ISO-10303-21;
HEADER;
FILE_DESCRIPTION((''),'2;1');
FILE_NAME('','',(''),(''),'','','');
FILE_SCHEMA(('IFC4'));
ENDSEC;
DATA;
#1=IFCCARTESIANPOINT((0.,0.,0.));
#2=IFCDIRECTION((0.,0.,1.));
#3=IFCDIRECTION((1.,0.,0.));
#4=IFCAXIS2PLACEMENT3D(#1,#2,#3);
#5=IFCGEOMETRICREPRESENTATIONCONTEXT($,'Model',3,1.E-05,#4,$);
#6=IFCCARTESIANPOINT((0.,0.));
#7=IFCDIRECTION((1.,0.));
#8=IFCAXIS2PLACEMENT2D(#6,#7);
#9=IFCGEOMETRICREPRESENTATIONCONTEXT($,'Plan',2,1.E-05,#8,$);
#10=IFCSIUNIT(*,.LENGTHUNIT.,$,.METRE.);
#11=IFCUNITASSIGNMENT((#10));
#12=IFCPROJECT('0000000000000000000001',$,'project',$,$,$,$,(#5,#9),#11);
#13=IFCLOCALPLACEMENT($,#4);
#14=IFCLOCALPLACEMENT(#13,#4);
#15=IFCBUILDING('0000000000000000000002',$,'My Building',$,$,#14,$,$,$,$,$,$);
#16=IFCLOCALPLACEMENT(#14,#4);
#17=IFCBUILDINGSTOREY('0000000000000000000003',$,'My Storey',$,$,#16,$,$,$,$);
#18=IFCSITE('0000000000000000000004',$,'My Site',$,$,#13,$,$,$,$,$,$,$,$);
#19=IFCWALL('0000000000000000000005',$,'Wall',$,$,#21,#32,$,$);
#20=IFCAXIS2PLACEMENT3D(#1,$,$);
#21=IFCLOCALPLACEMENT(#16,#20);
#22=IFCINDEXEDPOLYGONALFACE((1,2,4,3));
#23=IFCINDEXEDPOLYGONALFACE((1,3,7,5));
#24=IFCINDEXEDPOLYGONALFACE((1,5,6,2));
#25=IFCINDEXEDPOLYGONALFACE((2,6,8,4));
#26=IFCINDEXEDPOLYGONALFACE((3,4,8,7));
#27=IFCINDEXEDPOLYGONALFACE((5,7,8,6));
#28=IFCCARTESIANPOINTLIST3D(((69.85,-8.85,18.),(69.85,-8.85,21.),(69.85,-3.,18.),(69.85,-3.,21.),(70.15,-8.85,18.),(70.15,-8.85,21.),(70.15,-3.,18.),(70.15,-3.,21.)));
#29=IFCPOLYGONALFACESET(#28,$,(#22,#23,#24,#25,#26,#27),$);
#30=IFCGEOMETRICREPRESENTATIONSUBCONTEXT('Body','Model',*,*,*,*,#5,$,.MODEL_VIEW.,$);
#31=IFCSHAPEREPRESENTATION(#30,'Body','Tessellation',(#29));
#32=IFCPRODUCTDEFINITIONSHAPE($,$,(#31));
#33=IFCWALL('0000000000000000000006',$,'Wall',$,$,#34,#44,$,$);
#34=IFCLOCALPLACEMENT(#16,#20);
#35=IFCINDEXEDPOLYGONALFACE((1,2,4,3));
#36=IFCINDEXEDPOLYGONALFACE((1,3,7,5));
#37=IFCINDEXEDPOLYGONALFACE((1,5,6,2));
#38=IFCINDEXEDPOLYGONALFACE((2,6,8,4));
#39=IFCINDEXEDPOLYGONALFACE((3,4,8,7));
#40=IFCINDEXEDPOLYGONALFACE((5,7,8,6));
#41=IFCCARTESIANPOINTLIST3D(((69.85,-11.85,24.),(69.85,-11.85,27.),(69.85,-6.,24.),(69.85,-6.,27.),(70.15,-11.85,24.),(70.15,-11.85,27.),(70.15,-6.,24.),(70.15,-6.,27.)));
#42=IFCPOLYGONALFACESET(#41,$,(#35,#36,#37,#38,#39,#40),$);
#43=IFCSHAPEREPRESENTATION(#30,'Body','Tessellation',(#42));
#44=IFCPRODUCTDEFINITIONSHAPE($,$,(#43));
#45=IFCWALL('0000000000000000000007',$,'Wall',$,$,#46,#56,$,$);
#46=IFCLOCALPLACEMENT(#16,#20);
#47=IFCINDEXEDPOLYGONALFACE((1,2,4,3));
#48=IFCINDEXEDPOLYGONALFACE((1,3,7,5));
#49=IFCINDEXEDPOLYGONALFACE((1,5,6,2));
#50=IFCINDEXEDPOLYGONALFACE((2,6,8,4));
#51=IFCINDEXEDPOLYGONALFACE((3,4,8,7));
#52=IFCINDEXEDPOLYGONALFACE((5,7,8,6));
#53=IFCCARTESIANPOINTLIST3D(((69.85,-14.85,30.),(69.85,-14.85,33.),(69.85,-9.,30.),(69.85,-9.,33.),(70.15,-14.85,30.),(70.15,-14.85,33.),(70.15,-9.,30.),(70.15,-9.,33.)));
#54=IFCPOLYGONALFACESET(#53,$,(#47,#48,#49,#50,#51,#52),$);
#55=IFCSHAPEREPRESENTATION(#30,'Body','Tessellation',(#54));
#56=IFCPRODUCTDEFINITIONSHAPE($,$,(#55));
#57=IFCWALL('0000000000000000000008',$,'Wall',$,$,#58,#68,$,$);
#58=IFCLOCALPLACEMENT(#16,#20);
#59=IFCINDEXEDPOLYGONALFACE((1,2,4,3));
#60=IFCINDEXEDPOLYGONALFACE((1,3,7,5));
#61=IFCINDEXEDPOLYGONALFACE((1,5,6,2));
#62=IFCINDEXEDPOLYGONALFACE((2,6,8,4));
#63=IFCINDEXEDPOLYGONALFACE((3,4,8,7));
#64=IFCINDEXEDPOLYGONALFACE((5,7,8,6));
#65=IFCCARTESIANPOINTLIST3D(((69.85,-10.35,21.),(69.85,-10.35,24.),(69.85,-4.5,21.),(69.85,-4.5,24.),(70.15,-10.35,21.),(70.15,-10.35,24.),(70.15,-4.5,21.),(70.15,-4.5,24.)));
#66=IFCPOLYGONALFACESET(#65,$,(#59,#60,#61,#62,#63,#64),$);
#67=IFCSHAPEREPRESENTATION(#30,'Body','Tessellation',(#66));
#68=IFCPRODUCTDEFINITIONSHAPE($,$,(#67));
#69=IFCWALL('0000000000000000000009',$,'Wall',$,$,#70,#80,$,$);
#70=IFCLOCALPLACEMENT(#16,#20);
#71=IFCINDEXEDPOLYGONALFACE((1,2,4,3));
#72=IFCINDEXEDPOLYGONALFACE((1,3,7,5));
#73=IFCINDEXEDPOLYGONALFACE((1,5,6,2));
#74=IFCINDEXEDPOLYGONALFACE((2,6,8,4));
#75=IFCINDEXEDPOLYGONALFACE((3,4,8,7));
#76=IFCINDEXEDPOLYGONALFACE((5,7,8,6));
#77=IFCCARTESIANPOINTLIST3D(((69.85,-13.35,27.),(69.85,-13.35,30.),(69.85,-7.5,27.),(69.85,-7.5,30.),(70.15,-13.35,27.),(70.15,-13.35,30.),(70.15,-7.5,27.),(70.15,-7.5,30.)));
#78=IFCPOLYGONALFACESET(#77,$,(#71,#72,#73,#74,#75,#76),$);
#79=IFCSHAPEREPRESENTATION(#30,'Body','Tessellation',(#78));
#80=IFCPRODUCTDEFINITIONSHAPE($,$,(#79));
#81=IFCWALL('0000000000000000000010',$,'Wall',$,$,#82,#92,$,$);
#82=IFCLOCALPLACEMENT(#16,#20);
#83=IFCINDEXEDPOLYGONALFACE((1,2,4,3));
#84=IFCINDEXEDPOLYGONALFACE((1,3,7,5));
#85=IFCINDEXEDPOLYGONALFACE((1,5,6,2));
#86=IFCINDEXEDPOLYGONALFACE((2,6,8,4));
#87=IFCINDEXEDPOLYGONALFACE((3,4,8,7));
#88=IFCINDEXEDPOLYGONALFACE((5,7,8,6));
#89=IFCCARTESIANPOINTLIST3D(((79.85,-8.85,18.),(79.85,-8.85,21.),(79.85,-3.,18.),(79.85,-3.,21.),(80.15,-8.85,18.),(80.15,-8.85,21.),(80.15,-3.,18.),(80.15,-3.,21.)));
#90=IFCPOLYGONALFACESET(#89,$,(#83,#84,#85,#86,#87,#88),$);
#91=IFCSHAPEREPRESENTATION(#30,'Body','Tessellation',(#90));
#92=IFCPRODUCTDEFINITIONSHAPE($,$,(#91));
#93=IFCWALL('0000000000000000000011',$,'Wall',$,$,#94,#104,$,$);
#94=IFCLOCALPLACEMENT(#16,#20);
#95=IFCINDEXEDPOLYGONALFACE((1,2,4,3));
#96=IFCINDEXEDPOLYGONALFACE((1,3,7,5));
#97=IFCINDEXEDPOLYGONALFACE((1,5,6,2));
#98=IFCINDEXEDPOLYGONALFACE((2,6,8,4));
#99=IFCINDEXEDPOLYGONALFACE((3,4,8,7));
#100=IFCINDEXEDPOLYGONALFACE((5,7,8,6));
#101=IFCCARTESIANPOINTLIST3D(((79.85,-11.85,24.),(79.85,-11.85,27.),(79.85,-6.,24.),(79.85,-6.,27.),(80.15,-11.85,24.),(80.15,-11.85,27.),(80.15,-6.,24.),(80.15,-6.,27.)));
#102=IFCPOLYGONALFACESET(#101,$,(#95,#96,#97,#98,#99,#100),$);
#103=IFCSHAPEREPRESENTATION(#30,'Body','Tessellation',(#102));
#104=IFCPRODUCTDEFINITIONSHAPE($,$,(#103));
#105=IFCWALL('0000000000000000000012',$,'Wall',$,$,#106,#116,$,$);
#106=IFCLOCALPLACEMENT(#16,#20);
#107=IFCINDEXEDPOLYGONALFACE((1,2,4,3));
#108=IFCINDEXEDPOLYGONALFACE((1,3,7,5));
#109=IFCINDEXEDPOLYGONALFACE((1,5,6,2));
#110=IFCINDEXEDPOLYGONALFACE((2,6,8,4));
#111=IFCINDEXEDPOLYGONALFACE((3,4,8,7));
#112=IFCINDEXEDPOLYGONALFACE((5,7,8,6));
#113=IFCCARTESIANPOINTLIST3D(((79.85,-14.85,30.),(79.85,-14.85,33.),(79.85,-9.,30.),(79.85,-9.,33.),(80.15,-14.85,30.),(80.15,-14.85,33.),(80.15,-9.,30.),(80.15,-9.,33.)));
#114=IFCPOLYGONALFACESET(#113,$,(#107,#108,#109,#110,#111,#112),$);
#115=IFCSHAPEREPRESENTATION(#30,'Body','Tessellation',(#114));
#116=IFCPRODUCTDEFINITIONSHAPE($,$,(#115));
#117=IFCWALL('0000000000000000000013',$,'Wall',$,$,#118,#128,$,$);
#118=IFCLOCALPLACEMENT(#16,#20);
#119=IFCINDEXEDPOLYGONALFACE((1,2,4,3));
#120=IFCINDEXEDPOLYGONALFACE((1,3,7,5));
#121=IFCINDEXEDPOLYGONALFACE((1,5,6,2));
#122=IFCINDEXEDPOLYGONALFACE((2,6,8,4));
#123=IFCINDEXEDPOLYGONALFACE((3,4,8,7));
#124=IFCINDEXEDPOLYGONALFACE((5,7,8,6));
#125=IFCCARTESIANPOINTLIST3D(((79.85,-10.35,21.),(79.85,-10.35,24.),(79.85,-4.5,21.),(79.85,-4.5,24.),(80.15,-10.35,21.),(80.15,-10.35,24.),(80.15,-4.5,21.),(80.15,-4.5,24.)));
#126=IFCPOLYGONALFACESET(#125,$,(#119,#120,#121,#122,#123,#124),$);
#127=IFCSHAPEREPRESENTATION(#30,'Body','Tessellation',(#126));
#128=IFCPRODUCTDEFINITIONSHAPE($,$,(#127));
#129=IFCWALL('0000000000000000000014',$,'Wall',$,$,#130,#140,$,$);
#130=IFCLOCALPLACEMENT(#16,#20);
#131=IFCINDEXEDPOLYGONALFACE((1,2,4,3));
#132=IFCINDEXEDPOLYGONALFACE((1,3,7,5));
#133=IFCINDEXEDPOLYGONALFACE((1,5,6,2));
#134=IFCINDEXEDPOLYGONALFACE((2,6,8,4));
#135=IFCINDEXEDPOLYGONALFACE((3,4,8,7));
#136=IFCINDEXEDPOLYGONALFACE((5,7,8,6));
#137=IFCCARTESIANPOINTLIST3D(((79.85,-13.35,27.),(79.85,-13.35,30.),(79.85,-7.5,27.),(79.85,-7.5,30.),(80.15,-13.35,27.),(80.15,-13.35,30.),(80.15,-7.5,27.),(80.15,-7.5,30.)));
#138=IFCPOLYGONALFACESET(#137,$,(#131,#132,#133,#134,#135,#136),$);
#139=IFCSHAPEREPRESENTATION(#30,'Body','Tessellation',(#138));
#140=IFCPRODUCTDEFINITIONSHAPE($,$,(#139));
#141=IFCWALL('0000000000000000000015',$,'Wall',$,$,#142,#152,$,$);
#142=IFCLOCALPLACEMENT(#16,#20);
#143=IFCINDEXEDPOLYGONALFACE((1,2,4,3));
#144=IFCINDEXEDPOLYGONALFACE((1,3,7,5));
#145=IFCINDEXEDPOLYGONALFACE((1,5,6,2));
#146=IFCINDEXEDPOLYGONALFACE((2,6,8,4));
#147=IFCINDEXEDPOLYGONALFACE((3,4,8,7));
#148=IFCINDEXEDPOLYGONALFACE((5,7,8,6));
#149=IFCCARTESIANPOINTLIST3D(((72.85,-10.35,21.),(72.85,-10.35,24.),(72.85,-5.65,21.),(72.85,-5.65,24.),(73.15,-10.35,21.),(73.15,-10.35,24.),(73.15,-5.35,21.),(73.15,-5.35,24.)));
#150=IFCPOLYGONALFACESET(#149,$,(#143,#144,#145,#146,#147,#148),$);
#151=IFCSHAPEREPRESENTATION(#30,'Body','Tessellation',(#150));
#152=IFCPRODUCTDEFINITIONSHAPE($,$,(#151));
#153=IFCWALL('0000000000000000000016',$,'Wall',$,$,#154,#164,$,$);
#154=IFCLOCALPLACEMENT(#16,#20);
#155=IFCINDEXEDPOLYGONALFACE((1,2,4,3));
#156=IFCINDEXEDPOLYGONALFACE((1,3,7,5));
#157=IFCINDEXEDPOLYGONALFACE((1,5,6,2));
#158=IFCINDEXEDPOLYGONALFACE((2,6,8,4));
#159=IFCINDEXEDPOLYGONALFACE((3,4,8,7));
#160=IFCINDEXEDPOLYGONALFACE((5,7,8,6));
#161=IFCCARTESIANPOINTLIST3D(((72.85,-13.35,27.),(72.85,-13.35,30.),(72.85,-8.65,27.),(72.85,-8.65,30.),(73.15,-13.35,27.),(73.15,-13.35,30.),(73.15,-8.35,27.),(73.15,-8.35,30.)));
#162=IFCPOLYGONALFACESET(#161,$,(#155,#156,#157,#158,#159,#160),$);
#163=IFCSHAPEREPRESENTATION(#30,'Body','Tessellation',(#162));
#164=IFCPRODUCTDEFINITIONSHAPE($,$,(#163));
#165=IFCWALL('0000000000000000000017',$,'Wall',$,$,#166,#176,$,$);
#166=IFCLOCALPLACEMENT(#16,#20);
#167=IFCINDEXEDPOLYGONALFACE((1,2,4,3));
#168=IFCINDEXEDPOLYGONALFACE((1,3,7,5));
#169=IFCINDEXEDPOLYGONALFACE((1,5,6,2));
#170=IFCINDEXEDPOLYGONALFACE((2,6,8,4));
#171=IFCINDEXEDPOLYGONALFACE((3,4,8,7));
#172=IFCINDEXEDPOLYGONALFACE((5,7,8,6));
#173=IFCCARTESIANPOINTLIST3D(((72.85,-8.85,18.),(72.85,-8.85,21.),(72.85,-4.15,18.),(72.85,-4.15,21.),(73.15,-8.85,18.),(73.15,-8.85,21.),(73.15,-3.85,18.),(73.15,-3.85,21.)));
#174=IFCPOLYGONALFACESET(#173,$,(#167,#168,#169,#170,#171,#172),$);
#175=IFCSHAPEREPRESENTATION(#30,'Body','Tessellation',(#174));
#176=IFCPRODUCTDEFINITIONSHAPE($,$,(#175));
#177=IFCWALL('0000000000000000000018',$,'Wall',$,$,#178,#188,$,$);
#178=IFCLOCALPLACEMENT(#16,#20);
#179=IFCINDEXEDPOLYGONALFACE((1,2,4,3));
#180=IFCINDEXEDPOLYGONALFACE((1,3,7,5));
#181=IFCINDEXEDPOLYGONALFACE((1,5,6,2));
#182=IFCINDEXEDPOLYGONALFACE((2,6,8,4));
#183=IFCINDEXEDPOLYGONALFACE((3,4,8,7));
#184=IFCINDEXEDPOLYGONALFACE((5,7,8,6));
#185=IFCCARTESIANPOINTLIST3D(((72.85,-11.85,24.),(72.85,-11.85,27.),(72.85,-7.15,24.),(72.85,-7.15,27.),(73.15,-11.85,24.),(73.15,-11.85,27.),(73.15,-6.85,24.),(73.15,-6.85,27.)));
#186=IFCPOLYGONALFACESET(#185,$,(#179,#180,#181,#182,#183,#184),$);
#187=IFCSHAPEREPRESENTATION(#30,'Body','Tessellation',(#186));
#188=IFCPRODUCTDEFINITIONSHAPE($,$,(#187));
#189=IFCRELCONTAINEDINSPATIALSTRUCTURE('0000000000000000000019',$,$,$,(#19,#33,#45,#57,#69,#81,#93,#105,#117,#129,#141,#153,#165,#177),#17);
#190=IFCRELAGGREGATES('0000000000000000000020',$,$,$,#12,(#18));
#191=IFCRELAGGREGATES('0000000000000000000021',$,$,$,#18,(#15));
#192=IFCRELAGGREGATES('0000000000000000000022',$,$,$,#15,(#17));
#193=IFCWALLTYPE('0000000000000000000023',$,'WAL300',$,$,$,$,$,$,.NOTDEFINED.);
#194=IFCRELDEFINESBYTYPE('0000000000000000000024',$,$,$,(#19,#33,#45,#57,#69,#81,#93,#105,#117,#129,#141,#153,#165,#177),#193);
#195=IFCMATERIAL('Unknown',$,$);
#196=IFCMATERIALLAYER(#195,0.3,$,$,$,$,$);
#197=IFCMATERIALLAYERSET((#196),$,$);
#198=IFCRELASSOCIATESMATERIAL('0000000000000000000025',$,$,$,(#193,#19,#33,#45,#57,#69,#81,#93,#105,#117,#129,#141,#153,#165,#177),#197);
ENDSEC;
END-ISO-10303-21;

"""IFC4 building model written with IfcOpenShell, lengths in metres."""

from ifc_helpers import new_model, si_unit, frame, origin_with_axes, origin_2d_with_axis, place, context, subcontext, project, spatial, line, indexed_curve, outline, extrude, material, layer, layer_set, layer_usage, type_object, element, save


model = new_model("IFC4")

# Units and contexts
model_context = context("Model", 3, precision=1e-05, world=origin_with_axes())
plan_context = context("Plan", 2, precision=1e-05, world=origin_2d_with_axis())
body_context = subcontext(model_context, "Body", "Model", "MODEL_VIEW")
ifc_project = project(units=[si_unit("LENGTHUNIT", "METRE")], contexts=[model_context, plan_context])

# Site, building, storey
site_placement = place(None, origin_with_axes())
site = spatial("IfcSite", under=ifc_project, at=site_placement, Name="My Site")
building_placement = place(site_placement, origin_with_axes())
building = spatial("IfcBuilding", under=site, at=building_placement, Name="My Building")
storey_placement = place(building_placement, origin_with_axes())
storey = spatial("IfcBuildingStorey", under=building, at=storey_placement, Name="My Storey")

# Walls
ifc_material = material(Name="Unknown")
ifc_layer = layer(ifc_material, 0.3)
ifc_layer_set = layer_set([ifc_layer])
ifc_layer_usage_1 = layer_usage(ifc_layer_set, "AXIS2", "POSITIVE", -0.15)
wall_type = type_object("IfcWallType", Name="WAL300", PredefinedType="NOTDEFINED", material=ifc_layer_set)
wall_1_placement = place(storey_placement, frame((70.0, -3.0, 18.0), z_axis=(0.0, 0.0, 1.0), x_axis=(0.0, -1.0, 0.0)))
element("IfcWall", 1, at=wall_1_placement, inside=storey, type_object=wall_type, material=ifc_layer_usage_1, Name="Wall", context=body_context, shape_type="SweptSolid", body=[
    extrude(outline(indexed_curve([(0.0, -0.15), (0.0, 0.15), (5.85, 0.15), (5.85, -0.15)], segments=[line(1, 2, 3, 4, 1)])), origin_with_axes(), (0.0, 0.0, 1.0), 3.0),
])
ifc_layer_usage_2 = layer_usage(ifc_layer_set, "AXIS2", "POSITIVE", -0.15)
wall_2_placement = place(storey_placement, frame((70.0, -6.0, 24.0), z_axis=(0.0, 0.0, 1.0), x_axis=(0.0, -1.0, 0.0)))
element("IfcWall", 2, at=wall_2_placement, inside=storey, type_object=wall_type, material=ifc_layer_usage_2, Name="Wall", context=body_context, shape_type="SweptSolid", body=[
    extrude(outline(indexed_curve([(0.0, -0.15), (0.0, 0.15), (5.85, 0.15), (5.85, -0.15)], segments=[line(1, 2, 3, 4, 1)])), origin_with_axes(), (0.0, 0.0, 1.0), 3.0),
])
ifc_layer_usage_3 = layer_usage(ifc_layer_set, "AXIS2", "POSITIVE", -0.15)
wall_3_placement = place(storey_placement, frame((70.0, -9.0, 30.0), z_axis=(0.0, 0.0, 1.0), x_axis=(0.0, -1.0, 0.0)))
element("IfcWall", 3, at=wall_3_placement, inside=storey, type_object=wall_type, material=ifc_layer_usage_3, Name="Wall", context=body_context, shape_type="SweptSolid", body=[
    extrude(outline(indexed_curve([(0.0, -0.15), (0.0, 0.15), (5.85, 0.15), (5.85, -0.15)], segments=[line(1, 2, 3, 4, 1)])), origin_with_axes(), (0.0, 0.0, 1.0), 3.0),
])
ifc_layer_usage_4 = layer_usage(ifc_layer_set, "AXIS2", "POSITIVE", -0.15)
wall_4_placement = place(storey_placement, frame((70.0, -4.5, 21.0), z_axis=(0.0, 0.0, 1.0), x_axis=(0.0, -1.0, 0.0)))
element("IfcWall", 4, at=wall_4_placement, inside=storey, type_object=wall_type, material=ifc_layer_usage_4, Name="Wall", context=body_context, shape_type="SweptSolid", body=[
    extrude(outline(indexed_curve([(0.0, -0.15), (0.0, 0.15), (5.85, 0.15), (5.85, -0.15)], segments=[line(1, 2, 3, 4, 1)])), origin_with_axes(), (0.0, 0.0, 1.0), 3.0),
])
ifc_layer_usage_5 = layer_usage(ifc_layer_set, "AXIS2", "POSITIVE", -0.15)
wall_5_placement = place(storey_placement, frame((70.0, -7.5, 27.0), z_axis=(0.0, 0.0, 1.0), x_axis=(0.0, -1.0, 0.0)))
element("IfcWall", 5, at=wall_5_placement, inside=storey, type_object=wall_type, material=ifc_layer_usage_5, Name="Wall", context=body_context, shape_type="SweptSolid", body=[
    extrude(outline(indexed_curve([(0.0, -0.15), (0.0, 0.15), (5.85, 0.15), (5.85, -0.15)], segments=[line(1, 2, 3, 4, 1)])), origin_with_axes(), (0.0, 0.0, 1.0), 3.0),
])
ifc_layer_usage_6 = layer_usage(ifc_layer_set, "AXIS2", "POSITIVE", -0.15)
wall_6_placement = place(storey_placement, frame((80.0, -9.0, 18.0), z_axis=(0.0, 0.0, 1.0), x_axis=(0.0, 1.0, 0.0)))
element("IfcWall", 6, at=wall_6_placement, inside=storey, type_object=wall_type, material=ifc_layer_usage_6, Name="Wall", context=body_context, shape_type="SweptSolid", body=[
    extrude(outline(indexed_curve([(0.15, -0.15), (0.15, 0.15), (6.0, 0.15), (6.0, -0.15)], segments=[line(1, 2, 3, 4, 1)])), origin_with_axes(), (0.0, 0.0, 1.0), 3.0),
])
ifc_layer_usage_7 = layer_usage(ifc_layer_set, "AXIS2", "POSITIVE", -0.15)
wall_7_placement = place(storey_placement, frame((80.0, -12.0, 24.0), z_axis=(0.0, 0.0, 1.0), x_axis=(0.0, 1.0, 0.0)))
element("IfcWall", 7, at=wall_7_placement, inside=storey, type_object=wall_type, material=ifc_layer_usage_7, Name="Wall", context=body_context, shape_type="SweptSolid", body=[
    extrude(outline(indexed_curve([(0.15, -0.15), (0.15, 0.15), (6.0, 0.15), (6.0, -0.15)], segments=[line(1, 2, 3, 4, 1)])), origin_with_axes(), (0.0, 0.0, 1.0), 3.0),
])
ifc_layer_usage_8 = layer_usage(ifc_layer_set, "AXIS2", "POSITIVE", -0.15)
wall_8_placement = place(storey_placement, frame((80.0, -15.0, 30.0), z_axis=(0.0, 0.0, 1.0), x_axis=(0.0, 1.0, 0.0)))
element("IfcWall", 8, at=wall_8_placement, inside=storey, type_object=wall_type, material=ifc_layer_usage_8, Name="Wall", context=body_context, shape_type="SweptSolid", body=[
    extrude(outline(indexed_curve([(0.15, -0.15), (0.15, 0.15), (6.0, 0.15), (6.0, -0.15)], segments=[line(1, 2, 3, 4, 1)])), origin_with_axes(), (0.0, 0.0, 1.0), 3.0),
])
ifc_layer_usage_9 = layer_usage(ifc_layer_set, "AXIS2", "POSITIVE", -0.15)
wall_9_placement = place(storey_placement, frame((80.0, -10.5, 21.0), z_axis=(0.0, 0.0, 1.0), x_axis=(0.0, 1.0, 0.0)))
element("IfcWall", 9, at=wall_9_placement, inside=storey, type_object=wall_type, material=ifc_layer_usage_9, Name="Wall", context=body_context, shape_type="SweptSolid", body=[
    extrude(outline(indexed_curve([(0.15, -0.15), (0.15, 0.15), (6.0, 0.15), (6.0, -0.15)], segments=[line(1, 2, 3, 4, 1)])), origin_with_axes(), (0.0, 0.0, 1.0), 3.0),
])
ifc_layer_usage_10 = layer_usage(ifc_layer_set, "AXIS2", "POSITIVE", -0.15)
wall_10_placement = place(storey_placement, frame((80.0, -13.5, 27.0), z_axis=(0.0, 0.0, 1.0), x_axis=(0.0, 1.0, 0.0)))
element("IfcWall", 10, at=wall_10_placement, inside=storey, type_object=wall_type, material=ifc_layer_usage_10, Name="Wall", context=body_context, shape_type="SweptSolid", body=[
    extrude(outline(indexed_curve([(0.15, -0.15), (0.15, 0.15), (6.0, 0.15), (6.0, -0.15)], segments=[line(1, 2, 3, 4, 1)])), origin_with_axes(), (0.0, 0.0, 1.0), 3.0),
])
ifc_layer_usage_11 = layer_usage(ifc_layer_set, "AXIS2", "POSITIVE", -0.15)
wall_11_placement = place(storey_placement, frame((73.0, -10.5, 21.0), z_axis=(0.0, 0.0, 1.0), x_axis=(0.0, 1.0, 0.0)))
element("IfcWall", 11, at=wall_11_placement, inside=storey, type_object=wall_type, material=ifc_layer_usage_11, Name="Wall", context=body_context, shape_type="SweptSolid", body=[
    extrude(outline(indexed_curve([(0.15, -0.15), (0.15, 0.15), (4.85, 0.15), (5.15, -0.15)], segments=[line(1, 2, 3, 4, 1)])), origin_with_axes(), (0.0, 0.0, 1.0), 3.0),
])
ifc_layer_usage_12 = layer_usage(ifc_layer_set, "AXIS2", "POSITIVE", -0.15)
wall_12_placement = place(storey_placement, frame((73.0, -13.5, 27.0), z_axis=(0.0, 0.0, 1.0), x_axis=(0.0, 1.0, 0.0)))
element("IfcWall", 12, at=wall_12_placement, inside=storey, type_object=wall_type, material=ifc_layer_usage_12, Name="Wall", context=body_context, shape_type="SweptSolid", body=[
    extrude(outline(indexed_curve([(0.15, -0.15), (0.15, 0.15), (4.85, 0.15), (5.15, -0.15)], segments=[line(1, 2, 3, 4, 1)])), origin_with_axes(), (0.0, 0.0, 1.0), 3.0),
])
ifc_layer_usage_13 = layer_usage(ifc_layer_set, "AXIS2", "POSITIVE", -0.15)
wall_13_placement = place(storey_placement, frame((73.0, -9.0, 18.0), z_axis=(0.0, 0.0, 1.0), x_axis=(0.0, 1.0, 0.0)))
element("IfcWall", 13, at=wall_13_placement, inside=storey, type_object=wall_type, material=ifc_layer_usage_13, Name="Wall", context=body_context, shape_type="SweptSolid", body=[
    extrude(outline(indexed_curve([(0.15, -0.15), (0.15, 0.15), (4.85, 0.15), (5.15, -0.15)], segments=[line(1, 2, 3, 4, 1)])), origin_with_axes(), (0.0, 0.0, 1.0), 3.0),
])
ifc_layer_usage_14 = layer_usage(ifc_layer_set, "AXIS2", "POSITIVE", -0.15)
wall_14_placement = place(storey_placement, frame((73.0, -12.0, 24.0), z_axis=(0.0, 0.0, 1.0), x_axis=(0.0, 1.0, 0.0)))
element("IfcWall", 14, at=wall_14_placement, inside=storey, type_object=wall_type, material=ifc_layer_usage_14, Name="Wall", context=body_context, shape_type="SweptSolid", body=[
    extrude(outline(indexed_curve([(0.15, -0.15), (0.15, 0.15), (4.85, 0.15), (5.15, -0.15)], segments=[line(1, 2, 3, 4, 1)])), origin_with_axes(), (0.0, 0.0, 1.0), 3.0),
])

save(model, "model.ifc")
